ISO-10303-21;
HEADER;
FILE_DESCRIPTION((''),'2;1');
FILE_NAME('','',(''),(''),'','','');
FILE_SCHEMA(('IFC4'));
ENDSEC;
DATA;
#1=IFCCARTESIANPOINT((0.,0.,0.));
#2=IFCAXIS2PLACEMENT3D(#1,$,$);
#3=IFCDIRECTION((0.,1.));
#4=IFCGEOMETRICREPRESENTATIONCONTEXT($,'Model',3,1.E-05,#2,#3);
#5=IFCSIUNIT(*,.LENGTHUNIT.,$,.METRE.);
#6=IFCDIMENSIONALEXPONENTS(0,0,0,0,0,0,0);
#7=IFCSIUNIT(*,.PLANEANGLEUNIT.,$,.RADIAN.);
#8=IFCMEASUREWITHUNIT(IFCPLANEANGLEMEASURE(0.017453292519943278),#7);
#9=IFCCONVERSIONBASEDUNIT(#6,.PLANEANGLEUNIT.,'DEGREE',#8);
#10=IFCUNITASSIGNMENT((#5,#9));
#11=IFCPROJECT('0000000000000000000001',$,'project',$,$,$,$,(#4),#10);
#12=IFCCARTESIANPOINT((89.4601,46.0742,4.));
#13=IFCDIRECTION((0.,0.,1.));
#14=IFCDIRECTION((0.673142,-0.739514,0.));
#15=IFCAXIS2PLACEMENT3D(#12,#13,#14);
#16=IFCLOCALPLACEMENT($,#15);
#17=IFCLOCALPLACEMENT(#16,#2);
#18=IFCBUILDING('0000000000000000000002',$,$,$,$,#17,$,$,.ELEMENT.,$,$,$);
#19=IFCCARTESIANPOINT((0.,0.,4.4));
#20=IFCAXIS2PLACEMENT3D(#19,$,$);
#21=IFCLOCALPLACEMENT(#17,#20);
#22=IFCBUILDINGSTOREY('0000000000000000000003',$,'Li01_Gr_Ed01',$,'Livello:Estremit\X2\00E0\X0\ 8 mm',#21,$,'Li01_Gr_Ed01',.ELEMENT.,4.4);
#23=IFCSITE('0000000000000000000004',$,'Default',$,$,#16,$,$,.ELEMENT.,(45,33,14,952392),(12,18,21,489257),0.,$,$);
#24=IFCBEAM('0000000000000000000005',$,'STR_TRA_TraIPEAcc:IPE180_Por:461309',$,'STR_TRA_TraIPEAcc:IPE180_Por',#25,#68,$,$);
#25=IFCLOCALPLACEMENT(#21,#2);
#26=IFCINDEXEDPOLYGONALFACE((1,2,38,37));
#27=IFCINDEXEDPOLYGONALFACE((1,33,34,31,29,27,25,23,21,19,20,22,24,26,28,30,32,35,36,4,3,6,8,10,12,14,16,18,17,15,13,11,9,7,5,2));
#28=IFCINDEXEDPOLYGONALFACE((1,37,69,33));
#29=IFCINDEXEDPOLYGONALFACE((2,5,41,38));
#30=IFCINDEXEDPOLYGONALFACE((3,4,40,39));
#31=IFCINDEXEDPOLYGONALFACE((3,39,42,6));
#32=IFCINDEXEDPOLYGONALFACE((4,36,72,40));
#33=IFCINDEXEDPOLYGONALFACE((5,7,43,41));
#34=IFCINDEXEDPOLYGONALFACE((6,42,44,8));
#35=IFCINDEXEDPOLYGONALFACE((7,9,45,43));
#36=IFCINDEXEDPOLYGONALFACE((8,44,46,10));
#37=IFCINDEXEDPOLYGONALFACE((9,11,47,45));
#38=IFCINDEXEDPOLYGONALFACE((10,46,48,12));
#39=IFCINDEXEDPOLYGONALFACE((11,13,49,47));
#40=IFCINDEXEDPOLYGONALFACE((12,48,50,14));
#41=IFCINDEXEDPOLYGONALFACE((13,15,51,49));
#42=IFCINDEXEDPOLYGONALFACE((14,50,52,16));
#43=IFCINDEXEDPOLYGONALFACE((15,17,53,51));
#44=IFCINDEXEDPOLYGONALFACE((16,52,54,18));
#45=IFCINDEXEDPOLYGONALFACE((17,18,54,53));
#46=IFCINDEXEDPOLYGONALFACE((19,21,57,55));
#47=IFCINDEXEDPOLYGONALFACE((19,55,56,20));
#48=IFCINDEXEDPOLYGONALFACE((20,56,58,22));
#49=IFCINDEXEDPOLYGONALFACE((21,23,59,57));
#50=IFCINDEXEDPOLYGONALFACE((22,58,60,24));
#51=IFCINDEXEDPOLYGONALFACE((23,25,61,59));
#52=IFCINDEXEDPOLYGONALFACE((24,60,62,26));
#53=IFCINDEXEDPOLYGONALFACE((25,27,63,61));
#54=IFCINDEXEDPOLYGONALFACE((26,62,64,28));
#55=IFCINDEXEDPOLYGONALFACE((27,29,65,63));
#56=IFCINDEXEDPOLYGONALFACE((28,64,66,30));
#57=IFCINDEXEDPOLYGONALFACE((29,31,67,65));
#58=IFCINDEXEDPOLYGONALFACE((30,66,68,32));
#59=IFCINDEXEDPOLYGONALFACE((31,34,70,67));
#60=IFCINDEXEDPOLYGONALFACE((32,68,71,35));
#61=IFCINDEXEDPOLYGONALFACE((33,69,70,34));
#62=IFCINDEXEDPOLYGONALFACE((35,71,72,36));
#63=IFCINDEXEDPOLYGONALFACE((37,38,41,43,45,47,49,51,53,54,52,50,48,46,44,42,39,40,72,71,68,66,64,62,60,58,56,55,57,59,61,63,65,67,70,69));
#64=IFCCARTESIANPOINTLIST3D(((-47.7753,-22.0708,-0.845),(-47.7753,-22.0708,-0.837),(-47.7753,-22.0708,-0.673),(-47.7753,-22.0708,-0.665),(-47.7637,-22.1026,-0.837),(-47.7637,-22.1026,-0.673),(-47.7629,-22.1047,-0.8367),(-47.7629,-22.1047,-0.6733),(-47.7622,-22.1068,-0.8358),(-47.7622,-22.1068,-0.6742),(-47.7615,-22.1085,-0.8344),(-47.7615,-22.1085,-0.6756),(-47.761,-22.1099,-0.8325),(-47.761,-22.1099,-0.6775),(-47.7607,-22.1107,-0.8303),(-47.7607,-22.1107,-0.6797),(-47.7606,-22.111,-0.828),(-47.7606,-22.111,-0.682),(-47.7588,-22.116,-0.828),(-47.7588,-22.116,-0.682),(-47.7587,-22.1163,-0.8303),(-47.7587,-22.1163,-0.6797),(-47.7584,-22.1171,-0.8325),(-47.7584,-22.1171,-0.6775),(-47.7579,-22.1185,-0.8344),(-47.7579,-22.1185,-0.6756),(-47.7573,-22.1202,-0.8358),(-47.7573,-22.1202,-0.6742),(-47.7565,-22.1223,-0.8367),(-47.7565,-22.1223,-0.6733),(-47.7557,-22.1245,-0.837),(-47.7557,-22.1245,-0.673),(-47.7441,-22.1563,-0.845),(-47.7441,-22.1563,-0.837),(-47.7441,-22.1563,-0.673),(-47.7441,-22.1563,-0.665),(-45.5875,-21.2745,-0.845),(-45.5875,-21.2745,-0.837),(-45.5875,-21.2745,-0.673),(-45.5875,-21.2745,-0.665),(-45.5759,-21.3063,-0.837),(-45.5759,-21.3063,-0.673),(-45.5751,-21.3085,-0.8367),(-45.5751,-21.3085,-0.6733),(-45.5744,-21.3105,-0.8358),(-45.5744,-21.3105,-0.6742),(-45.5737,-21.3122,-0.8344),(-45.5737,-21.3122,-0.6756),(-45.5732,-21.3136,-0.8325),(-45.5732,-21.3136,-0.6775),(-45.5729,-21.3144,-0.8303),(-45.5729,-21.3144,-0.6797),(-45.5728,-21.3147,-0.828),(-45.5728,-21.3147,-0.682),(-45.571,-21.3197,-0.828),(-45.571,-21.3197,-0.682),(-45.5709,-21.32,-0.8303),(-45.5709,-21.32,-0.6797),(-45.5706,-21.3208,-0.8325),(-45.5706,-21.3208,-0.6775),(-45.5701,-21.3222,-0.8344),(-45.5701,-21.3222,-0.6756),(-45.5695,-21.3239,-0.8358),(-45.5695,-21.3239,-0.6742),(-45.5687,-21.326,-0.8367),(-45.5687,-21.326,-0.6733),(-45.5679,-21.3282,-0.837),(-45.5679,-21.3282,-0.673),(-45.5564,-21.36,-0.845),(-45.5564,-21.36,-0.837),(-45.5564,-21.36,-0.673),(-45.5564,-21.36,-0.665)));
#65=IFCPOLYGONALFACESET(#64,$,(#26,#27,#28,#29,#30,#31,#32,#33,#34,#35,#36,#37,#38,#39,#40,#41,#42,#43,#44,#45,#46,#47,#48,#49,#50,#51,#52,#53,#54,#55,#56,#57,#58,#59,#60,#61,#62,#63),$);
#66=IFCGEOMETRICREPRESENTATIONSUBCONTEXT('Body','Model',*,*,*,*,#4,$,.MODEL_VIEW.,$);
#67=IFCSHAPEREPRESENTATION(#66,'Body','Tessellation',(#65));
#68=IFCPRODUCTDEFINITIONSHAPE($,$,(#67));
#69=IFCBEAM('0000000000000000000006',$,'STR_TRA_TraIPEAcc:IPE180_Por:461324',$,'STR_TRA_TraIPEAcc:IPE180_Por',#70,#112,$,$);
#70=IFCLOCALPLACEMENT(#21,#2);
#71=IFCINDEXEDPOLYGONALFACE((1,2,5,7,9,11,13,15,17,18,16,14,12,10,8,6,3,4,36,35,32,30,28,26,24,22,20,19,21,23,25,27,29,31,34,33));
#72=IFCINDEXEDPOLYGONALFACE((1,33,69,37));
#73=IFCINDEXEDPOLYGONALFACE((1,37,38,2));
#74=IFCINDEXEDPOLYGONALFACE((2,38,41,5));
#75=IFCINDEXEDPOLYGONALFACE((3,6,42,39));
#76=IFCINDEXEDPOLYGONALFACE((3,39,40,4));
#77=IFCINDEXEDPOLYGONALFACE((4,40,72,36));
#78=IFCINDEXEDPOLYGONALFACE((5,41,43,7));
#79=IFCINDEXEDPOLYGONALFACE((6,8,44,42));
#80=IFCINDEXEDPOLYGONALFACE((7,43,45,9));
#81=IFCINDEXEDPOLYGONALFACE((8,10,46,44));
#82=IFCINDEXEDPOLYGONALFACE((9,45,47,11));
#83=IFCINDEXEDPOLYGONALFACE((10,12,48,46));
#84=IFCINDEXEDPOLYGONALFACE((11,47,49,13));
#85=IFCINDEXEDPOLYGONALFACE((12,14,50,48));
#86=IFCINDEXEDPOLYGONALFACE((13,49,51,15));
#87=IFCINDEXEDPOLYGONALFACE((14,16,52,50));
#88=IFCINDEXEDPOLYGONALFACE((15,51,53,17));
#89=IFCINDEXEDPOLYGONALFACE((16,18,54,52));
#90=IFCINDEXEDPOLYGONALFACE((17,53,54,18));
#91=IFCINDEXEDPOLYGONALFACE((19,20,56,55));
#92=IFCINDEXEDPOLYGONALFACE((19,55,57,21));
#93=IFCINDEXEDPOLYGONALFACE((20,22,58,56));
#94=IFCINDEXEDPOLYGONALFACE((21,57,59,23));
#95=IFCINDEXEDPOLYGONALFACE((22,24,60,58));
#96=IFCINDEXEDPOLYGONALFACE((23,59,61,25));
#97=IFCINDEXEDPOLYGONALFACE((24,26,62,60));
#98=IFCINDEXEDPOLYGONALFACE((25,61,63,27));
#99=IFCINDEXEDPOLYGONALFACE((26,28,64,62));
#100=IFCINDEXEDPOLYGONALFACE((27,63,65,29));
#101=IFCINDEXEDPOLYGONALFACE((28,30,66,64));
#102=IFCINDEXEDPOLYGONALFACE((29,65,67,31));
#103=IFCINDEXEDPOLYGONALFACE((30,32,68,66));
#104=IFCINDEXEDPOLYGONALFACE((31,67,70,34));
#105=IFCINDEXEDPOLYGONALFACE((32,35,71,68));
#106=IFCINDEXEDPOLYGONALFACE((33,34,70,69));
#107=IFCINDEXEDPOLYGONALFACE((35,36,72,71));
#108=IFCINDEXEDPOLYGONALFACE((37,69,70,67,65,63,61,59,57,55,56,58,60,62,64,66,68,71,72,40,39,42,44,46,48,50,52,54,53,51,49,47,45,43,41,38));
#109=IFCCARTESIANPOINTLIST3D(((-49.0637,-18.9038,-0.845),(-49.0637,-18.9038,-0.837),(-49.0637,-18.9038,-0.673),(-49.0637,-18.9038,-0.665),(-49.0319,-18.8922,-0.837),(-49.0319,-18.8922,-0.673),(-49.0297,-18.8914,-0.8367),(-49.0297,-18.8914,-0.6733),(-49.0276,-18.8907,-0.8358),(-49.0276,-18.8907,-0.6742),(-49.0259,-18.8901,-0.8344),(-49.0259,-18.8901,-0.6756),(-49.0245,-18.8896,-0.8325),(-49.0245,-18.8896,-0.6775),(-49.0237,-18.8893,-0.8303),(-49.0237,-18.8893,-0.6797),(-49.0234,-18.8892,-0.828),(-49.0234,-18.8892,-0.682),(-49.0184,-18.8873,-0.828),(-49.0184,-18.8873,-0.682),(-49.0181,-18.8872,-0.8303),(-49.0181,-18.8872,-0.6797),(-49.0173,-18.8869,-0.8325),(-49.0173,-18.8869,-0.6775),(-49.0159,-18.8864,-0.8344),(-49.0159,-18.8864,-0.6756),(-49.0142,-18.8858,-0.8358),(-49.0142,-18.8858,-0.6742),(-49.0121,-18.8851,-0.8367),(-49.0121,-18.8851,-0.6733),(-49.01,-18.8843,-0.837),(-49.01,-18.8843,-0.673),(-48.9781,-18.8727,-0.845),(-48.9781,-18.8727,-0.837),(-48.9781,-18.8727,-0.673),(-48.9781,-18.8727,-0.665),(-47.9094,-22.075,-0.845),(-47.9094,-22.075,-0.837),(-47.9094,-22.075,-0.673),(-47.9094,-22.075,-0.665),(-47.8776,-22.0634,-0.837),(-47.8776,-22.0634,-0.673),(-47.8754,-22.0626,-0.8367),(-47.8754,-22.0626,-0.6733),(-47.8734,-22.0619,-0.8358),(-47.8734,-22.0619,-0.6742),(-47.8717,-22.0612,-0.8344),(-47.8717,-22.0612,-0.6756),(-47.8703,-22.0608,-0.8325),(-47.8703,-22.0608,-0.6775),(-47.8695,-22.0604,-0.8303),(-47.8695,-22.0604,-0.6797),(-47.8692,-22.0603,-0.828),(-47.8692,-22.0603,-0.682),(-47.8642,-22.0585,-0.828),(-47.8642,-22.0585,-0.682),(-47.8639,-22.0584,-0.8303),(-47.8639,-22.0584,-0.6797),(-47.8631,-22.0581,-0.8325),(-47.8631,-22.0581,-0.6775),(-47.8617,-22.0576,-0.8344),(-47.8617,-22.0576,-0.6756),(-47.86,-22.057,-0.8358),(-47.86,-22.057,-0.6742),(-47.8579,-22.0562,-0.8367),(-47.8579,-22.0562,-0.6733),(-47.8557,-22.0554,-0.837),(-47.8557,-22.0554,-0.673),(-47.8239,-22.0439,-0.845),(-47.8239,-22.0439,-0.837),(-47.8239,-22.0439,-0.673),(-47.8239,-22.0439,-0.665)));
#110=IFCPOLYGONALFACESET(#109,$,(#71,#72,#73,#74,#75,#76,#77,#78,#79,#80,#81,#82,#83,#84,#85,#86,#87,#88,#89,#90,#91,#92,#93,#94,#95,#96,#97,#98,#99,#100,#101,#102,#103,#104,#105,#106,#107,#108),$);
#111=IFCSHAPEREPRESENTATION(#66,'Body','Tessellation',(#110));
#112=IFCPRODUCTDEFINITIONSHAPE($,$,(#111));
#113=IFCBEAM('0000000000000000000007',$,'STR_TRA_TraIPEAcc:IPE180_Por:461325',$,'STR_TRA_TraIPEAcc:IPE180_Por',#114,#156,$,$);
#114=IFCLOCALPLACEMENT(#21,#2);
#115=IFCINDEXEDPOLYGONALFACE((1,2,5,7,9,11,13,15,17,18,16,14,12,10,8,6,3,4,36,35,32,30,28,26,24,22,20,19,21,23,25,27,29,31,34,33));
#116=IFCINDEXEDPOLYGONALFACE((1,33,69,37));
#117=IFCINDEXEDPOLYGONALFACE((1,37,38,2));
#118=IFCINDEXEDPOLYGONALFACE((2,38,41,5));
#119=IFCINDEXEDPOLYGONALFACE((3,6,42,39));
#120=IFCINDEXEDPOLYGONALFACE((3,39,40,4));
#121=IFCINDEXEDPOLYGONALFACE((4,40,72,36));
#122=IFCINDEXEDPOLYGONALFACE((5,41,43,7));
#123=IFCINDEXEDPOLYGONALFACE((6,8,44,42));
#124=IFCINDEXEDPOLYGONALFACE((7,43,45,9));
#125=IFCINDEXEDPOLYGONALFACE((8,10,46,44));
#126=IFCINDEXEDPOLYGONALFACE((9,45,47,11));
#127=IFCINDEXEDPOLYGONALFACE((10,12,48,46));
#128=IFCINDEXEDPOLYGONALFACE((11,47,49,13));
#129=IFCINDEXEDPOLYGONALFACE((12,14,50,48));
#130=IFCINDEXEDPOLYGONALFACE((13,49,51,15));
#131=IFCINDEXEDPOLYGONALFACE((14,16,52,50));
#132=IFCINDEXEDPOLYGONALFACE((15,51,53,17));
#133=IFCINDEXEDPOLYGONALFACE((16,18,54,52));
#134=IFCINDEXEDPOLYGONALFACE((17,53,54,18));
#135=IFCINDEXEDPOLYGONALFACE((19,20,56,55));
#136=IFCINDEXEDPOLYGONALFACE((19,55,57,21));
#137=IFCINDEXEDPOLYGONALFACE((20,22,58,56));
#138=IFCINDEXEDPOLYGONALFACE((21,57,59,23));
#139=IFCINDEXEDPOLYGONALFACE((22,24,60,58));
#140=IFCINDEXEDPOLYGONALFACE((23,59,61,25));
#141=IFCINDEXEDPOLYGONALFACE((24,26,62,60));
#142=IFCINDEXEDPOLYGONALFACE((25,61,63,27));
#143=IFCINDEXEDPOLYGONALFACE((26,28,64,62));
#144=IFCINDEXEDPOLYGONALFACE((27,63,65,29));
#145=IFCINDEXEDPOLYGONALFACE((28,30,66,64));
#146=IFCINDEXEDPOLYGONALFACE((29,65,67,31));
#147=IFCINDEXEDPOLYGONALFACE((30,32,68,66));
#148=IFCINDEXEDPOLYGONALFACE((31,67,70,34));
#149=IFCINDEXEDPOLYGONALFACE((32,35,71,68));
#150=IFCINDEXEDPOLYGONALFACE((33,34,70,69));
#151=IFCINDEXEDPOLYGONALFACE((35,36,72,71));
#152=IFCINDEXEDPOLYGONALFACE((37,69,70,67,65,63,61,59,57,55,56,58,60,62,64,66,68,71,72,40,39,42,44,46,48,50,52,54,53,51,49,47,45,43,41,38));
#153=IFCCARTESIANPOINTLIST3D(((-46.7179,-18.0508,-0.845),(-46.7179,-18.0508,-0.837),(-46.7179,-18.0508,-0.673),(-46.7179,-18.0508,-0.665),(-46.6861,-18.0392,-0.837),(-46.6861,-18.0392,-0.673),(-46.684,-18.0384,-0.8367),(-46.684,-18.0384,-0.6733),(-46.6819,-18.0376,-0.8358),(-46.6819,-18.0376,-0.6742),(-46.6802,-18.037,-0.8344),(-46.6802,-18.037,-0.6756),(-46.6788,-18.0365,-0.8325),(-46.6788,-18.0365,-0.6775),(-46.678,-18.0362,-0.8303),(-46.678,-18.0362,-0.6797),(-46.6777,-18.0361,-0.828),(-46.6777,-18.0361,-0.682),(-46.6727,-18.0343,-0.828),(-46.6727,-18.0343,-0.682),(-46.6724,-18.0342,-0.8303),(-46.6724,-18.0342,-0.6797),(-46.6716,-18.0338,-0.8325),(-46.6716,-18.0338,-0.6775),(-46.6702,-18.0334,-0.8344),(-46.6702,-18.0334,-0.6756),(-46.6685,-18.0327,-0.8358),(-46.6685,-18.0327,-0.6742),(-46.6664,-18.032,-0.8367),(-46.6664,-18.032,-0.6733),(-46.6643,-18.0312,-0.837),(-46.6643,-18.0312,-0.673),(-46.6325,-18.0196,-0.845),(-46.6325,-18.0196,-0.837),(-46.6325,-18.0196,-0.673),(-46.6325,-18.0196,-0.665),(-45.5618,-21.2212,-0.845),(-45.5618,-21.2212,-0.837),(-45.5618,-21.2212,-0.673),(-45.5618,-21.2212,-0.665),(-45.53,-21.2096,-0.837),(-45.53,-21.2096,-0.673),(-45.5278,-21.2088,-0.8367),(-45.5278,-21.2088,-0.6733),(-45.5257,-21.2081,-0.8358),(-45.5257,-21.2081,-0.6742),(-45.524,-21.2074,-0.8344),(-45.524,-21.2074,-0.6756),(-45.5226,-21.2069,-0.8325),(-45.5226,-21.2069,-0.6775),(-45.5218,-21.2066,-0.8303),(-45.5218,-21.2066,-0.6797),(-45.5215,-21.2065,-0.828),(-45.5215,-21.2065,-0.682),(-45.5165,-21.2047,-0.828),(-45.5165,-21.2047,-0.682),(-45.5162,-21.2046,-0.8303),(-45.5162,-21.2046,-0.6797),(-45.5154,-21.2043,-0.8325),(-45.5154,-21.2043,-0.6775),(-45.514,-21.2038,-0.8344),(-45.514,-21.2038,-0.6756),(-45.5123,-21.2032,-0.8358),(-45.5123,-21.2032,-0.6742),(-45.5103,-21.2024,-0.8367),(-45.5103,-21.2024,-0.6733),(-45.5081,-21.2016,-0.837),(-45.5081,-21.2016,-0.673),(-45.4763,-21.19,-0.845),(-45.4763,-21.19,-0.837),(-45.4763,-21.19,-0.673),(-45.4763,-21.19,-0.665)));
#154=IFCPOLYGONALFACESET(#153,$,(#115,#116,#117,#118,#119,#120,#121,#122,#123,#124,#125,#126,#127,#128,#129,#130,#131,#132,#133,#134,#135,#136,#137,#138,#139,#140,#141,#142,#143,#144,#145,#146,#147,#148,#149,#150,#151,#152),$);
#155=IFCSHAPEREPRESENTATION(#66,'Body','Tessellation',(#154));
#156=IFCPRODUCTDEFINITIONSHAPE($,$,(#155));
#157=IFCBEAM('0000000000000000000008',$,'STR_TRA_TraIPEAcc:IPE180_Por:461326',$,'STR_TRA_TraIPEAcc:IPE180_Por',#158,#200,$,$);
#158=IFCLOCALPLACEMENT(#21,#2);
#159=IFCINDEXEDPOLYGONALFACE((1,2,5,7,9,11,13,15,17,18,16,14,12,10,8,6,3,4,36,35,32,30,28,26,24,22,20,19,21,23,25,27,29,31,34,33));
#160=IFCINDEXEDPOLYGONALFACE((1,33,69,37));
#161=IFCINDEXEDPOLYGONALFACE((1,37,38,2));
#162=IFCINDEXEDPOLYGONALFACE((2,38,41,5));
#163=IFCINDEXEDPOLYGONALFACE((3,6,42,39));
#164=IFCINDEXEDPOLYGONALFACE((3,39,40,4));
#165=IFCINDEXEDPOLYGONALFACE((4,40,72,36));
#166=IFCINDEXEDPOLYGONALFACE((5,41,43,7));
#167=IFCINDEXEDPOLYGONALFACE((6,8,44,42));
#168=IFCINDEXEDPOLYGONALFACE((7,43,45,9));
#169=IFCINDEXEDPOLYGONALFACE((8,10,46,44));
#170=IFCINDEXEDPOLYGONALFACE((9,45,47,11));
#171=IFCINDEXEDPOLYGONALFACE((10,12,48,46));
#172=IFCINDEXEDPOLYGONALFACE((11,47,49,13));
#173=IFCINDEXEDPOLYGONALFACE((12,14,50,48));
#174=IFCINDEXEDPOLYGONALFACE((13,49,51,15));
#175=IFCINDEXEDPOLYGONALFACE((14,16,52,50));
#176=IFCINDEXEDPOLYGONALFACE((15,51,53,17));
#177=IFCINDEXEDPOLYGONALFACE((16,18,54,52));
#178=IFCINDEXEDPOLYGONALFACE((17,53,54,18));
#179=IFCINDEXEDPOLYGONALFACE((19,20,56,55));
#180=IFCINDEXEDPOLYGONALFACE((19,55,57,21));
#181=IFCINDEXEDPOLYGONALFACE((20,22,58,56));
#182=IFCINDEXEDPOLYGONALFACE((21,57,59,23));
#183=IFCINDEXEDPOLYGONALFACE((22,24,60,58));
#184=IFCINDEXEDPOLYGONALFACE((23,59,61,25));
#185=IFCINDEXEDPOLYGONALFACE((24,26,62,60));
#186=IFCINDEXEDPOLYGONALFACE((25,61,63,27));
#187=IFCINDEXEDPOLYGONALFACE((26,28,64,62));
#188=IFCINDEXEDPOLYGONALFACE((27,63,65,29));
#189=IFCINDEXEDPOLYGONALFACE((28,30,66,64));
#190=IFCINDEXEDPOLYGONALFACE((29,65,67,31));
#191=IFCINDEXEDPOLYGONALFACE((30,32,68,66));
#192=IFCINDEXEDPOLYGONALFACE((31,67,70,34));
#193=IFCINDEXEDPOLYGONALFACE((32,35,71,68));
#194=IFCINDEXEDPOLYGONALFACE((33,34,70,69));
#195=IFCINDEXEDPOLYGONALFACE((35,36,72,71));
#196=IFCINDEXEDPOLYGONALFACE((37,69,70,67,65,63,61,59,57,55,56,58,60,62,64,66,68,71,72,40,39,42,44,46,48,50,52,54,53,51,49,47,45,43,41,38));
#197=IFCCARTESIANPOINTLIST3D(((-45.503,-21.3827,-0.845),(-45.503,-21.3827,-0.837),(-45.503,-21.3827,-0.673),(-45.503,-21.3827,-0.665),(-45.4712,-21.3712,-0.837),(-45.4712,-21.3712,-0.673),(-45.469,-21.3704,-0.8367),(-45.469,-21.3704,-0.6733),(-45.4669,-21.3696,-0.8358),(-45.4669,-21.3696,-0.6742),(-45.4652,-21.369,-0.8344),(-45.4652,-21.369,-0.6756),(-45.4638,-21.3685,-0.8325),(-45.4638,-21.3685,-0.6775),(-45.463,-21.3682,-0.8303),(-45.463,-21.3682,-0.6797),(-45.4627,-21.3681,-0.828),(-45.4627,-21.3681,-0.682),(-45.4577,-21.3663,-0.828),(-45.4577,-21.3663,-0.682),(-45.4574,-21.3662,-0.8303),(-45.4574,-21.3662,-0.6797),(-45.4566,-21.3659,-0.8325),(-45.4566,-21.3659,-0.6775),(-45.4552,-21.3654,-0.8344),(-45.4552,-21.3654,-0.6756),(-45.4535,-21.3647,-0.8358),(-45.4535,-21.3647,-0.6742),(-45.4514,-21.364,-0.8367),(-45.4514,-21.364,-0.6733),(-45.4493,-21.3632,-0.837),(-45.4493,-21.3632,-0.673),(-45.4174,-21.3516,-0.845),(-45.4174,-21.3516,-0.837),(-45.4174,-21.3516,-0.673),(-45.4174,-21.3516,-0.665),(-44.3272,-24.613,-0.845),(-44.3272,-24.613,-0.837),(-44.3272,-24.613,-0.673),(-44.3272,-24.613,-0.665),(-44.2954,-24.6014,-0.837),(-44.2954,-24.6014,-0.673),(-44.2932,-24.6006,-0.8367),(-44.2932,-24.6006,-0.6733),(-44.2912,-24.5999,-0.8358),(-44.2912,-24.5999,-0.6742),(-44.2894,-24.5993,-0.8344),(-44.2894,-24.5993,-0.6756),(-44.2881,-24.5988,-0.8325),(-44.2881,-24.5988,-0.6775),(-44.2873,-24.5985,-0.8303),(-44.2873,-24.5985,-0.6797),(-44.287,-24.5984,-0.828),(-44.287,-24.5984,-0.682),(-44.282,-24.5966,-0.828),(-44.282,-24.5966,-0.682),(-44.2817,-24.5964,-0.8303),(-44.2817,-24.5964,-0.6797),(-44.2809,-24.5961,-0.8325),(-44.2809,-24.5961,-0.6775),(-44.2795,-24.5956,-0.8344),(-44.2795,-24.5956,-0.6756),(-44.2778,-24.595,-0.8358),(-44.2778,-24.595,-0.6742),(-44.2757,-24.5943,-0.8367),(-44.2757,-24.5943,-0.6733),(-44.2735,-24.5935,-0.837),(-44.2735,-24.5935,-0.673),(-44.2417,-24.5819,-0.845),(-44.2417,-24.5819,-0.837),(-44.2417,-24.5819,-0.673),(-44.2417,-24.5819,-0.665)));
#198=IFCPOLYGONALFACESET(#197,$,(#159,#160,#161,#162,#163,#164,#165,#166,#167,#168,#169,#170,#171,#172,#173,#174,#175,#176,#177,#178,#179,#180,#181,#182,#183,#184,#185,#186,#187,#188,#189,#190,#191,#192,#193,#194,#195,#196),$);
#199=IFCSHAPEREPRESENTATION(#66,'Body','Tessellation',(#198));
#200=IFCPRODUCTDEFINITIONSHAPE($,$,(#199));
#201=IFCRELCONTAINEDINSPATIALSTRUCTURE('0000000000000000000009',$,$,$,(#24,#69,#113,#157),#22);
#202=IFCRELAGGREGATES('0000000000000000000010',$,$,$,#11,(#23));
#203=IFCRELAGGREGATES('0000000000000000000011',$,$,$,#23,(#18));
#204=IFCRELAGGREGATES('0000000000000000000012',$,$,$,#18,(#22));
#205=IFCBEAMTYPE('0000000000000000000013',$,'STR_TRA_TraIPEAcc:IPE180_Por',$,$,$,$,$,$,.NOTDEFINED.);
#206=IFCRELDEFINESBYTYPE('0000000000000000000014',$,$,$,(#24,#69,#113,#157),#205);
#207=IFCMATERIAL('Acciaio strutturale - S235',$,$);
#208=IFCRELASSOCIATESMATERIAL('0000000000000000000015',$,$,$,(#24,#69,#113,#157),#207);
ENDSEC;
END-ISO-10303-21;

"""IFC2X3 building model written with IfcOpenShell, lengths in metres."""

from ifc_helpers import new_model, entity, si_unit, converted_unit, direction, frame, frame_2d, origin, place, context, subcontext, project, spatial, i_section, extrude, material, type_object, element, save


model = new_model("IFC2X3")

# Units and contexts
model_context = context("Model", 3, precision=1e-05, world=origin(), true_north=direction((0.0, 1.0)))
body_context = subcontext(model_context, "Body", "Model", "MODEL_VIEW")
ifc_project = project(units=[si_unit("LENGTHUNIT", "METRE"), converted_unit("PLANEANGLEUNIT", "DEGREE", entity("IfcPlaneAngleMeasure", 0.017453292519943278), si_unit("PLANEANGLEUNIT", "RADIAN"), dimensions=[0, 0, 0, 0, 0, 0, 0])], contexts=[model_context])

# Site, building, storey
site_placement = place(None, frame((89.4601, 46.0742, 4.0), z_axis=(0.0, 0.0, 1.0), x_axis=(0.673142, -0.739514, 0.0)))
site = spatial("IfcSite", under=ifc_project, at=site_placement, Name="Default", CompositionType="ELEMENT", RefLatitude=(45, 33, 14, 952392), RefLongitude=(12, 18, 21, 489257), RefElevation=0.0)
building_placement = place(site_placement, origin())
building = spatial("IfcBuilding", under=site, at=building_placement, CompositionType="ELEMENT")
storey_placement = place(building_placement, frame((0.0, 0.0, 4.4)))
storey = spatial("IfcBuildingStorey", under=building, at=storey_placement, Name="Li01_Gr_Ed01", ObjectType="Livello:Estremità 8 mm", LongName="Li01_Gr_Ed01", CompositionType="ELEMENT", Elevation=4.4)

# Beams
ifc_material_1 = material(Name="Acciaio strutturale - S235")
beam_type = type_object("IfcBeamType", Name="STR_TRA_TraIPEAcc:IPE180_Por", PredefinedType="NOTDEFINED")
beam_1_placement = place(storey_placement, frame((-47.8368, -22.1416, -0.665), z_axis=(0.0, 0.0, 1.0), x_axis=(0.939693, 0.34202, 0.0)))
element("IfcBeam", 1, at=beam_1_placement, inside=storey, type_object=beam_type, material=ifc_material_1, Name="STR_TRA_TraIPEAcc:IPE180_Por:461309", ObjectType="STR_TRA_TraIPEAcc:IPE180_Por", context=body_context, shape_type="SweptSolid", body=[
    extrude(i_section(OverallWidth=0.091, OverallDepth=0.18, WebThickness=0.0053, FlangeThickness=0.008, FilletRadius=0.009, at=frame_2d((0.0, 0.0), x_axis=(0.0, 1.0))), frame((0.082, 0.0, -0.09), z_axis=(1.0, 0.0, 0.0), x_axis=(0.0, 0.0, -1.0)), (0.0, 0.0, 1.0), 2.3282),
])
beam_2_placement = place(storey_placement, frame((-47.8368, -22.1416, -0.665), z_axis=(0.0, 0.0, 1.0), x_axis=(-0.34202, 0.939693, 0.0)))
element("IfcBeam", 2, at=beam_2_placement, inside=storey, type_object=beam_type, material=ifc_material_1, Name="STR_TRA_TraIPEAcc:IPE180_Por:461324", ObjectType="STR_TRA_TraIPEAcc:IPE180_Por", context=body_context, shape_type="SweptSolid", body=[
    extrude(i_section(OverallWidth=0.091, OverallDepth=0.18, WebThickness=0.0053, FlangeThickness=0.008, FilletRadius=0.009, at=frame_2d((0.0, 0.0), x_axis=(0.0, 1.0))), frame((0.0874, 0.0, -0.09), z_axis=(1.0, 0.0, 0.0), x_axis=(0.0, 0.0, -1.0)), (0.0, 0.0, 1.0), 3.3747),
])
beam_3_placement = place(storey_placement, frame((-46.6735, -18.0398, -0.665), z_axis=(0.0, 0.0, 1.0), x_axis=(0.342606, -0.939479, 0.0)))
element("IfcBeam", 3, at=beam_3_placement, inside=storey, type_object=beam_type, material=ifc_material_1, Name="STR_TRA_TraIPEAcc:IPE180_Por:461325", ObjectType="STR_TRA_TraIPEAcc:IPE180_Por", context=body_context, shape_type="SweptSolid", body=[
    extrude(i_section(OverallWidth=0.091, OverallDepth=0.18, WebThickness=0.0053, FlangeThickness=0.008, FilletRadius=0.009, at=frame_2d((0.0, 0.0), x_axis=(0.0, 1.0))), frame((-0.0049, 0.0, -0.09), z_axis=(1.0, 0.0, 0.0), x_axis=(0.0, 0.0, -1.0)), (0.0, 0.0, 1.0), 3.3747),
])
beam_4_placement = place(storey_placement, frame((-45.4519, -21.3901, -0.665), z_axis=(0.0, 0.0, 1.0), x_axis=(0.34202, -0.939693, 0.0)))
element("IfcBeam", 4, at=beam_4_placement, inside=storey, type_object=beam_type, material=ifc_material_1, Name="STR_TRA_TraIPEAcc:IPE180_Por:461326", ObjectType="STR_TRA_TraIPEAcc:IPE180_Por", context=body_context, shape_type="SweptSolid", body=[
    extrude(i_section(OverallWidth=0.091, OverallDepth=0.18, WebThickness=0.0053, FlangeThickness=0.008, FilletRadius=0.009, at=frame_2d((0.0, 0.0), x_axis=(0.0, 1.0))), frame((-0.0244, 0.0, -0.09), z_axis=(1.0, 0.0, 0.0), x_axis=(0.0, 0.0, -1.0)), (0.0, 0.0, 1.0), 3.4376),
])

save(model, "model.ifc")
